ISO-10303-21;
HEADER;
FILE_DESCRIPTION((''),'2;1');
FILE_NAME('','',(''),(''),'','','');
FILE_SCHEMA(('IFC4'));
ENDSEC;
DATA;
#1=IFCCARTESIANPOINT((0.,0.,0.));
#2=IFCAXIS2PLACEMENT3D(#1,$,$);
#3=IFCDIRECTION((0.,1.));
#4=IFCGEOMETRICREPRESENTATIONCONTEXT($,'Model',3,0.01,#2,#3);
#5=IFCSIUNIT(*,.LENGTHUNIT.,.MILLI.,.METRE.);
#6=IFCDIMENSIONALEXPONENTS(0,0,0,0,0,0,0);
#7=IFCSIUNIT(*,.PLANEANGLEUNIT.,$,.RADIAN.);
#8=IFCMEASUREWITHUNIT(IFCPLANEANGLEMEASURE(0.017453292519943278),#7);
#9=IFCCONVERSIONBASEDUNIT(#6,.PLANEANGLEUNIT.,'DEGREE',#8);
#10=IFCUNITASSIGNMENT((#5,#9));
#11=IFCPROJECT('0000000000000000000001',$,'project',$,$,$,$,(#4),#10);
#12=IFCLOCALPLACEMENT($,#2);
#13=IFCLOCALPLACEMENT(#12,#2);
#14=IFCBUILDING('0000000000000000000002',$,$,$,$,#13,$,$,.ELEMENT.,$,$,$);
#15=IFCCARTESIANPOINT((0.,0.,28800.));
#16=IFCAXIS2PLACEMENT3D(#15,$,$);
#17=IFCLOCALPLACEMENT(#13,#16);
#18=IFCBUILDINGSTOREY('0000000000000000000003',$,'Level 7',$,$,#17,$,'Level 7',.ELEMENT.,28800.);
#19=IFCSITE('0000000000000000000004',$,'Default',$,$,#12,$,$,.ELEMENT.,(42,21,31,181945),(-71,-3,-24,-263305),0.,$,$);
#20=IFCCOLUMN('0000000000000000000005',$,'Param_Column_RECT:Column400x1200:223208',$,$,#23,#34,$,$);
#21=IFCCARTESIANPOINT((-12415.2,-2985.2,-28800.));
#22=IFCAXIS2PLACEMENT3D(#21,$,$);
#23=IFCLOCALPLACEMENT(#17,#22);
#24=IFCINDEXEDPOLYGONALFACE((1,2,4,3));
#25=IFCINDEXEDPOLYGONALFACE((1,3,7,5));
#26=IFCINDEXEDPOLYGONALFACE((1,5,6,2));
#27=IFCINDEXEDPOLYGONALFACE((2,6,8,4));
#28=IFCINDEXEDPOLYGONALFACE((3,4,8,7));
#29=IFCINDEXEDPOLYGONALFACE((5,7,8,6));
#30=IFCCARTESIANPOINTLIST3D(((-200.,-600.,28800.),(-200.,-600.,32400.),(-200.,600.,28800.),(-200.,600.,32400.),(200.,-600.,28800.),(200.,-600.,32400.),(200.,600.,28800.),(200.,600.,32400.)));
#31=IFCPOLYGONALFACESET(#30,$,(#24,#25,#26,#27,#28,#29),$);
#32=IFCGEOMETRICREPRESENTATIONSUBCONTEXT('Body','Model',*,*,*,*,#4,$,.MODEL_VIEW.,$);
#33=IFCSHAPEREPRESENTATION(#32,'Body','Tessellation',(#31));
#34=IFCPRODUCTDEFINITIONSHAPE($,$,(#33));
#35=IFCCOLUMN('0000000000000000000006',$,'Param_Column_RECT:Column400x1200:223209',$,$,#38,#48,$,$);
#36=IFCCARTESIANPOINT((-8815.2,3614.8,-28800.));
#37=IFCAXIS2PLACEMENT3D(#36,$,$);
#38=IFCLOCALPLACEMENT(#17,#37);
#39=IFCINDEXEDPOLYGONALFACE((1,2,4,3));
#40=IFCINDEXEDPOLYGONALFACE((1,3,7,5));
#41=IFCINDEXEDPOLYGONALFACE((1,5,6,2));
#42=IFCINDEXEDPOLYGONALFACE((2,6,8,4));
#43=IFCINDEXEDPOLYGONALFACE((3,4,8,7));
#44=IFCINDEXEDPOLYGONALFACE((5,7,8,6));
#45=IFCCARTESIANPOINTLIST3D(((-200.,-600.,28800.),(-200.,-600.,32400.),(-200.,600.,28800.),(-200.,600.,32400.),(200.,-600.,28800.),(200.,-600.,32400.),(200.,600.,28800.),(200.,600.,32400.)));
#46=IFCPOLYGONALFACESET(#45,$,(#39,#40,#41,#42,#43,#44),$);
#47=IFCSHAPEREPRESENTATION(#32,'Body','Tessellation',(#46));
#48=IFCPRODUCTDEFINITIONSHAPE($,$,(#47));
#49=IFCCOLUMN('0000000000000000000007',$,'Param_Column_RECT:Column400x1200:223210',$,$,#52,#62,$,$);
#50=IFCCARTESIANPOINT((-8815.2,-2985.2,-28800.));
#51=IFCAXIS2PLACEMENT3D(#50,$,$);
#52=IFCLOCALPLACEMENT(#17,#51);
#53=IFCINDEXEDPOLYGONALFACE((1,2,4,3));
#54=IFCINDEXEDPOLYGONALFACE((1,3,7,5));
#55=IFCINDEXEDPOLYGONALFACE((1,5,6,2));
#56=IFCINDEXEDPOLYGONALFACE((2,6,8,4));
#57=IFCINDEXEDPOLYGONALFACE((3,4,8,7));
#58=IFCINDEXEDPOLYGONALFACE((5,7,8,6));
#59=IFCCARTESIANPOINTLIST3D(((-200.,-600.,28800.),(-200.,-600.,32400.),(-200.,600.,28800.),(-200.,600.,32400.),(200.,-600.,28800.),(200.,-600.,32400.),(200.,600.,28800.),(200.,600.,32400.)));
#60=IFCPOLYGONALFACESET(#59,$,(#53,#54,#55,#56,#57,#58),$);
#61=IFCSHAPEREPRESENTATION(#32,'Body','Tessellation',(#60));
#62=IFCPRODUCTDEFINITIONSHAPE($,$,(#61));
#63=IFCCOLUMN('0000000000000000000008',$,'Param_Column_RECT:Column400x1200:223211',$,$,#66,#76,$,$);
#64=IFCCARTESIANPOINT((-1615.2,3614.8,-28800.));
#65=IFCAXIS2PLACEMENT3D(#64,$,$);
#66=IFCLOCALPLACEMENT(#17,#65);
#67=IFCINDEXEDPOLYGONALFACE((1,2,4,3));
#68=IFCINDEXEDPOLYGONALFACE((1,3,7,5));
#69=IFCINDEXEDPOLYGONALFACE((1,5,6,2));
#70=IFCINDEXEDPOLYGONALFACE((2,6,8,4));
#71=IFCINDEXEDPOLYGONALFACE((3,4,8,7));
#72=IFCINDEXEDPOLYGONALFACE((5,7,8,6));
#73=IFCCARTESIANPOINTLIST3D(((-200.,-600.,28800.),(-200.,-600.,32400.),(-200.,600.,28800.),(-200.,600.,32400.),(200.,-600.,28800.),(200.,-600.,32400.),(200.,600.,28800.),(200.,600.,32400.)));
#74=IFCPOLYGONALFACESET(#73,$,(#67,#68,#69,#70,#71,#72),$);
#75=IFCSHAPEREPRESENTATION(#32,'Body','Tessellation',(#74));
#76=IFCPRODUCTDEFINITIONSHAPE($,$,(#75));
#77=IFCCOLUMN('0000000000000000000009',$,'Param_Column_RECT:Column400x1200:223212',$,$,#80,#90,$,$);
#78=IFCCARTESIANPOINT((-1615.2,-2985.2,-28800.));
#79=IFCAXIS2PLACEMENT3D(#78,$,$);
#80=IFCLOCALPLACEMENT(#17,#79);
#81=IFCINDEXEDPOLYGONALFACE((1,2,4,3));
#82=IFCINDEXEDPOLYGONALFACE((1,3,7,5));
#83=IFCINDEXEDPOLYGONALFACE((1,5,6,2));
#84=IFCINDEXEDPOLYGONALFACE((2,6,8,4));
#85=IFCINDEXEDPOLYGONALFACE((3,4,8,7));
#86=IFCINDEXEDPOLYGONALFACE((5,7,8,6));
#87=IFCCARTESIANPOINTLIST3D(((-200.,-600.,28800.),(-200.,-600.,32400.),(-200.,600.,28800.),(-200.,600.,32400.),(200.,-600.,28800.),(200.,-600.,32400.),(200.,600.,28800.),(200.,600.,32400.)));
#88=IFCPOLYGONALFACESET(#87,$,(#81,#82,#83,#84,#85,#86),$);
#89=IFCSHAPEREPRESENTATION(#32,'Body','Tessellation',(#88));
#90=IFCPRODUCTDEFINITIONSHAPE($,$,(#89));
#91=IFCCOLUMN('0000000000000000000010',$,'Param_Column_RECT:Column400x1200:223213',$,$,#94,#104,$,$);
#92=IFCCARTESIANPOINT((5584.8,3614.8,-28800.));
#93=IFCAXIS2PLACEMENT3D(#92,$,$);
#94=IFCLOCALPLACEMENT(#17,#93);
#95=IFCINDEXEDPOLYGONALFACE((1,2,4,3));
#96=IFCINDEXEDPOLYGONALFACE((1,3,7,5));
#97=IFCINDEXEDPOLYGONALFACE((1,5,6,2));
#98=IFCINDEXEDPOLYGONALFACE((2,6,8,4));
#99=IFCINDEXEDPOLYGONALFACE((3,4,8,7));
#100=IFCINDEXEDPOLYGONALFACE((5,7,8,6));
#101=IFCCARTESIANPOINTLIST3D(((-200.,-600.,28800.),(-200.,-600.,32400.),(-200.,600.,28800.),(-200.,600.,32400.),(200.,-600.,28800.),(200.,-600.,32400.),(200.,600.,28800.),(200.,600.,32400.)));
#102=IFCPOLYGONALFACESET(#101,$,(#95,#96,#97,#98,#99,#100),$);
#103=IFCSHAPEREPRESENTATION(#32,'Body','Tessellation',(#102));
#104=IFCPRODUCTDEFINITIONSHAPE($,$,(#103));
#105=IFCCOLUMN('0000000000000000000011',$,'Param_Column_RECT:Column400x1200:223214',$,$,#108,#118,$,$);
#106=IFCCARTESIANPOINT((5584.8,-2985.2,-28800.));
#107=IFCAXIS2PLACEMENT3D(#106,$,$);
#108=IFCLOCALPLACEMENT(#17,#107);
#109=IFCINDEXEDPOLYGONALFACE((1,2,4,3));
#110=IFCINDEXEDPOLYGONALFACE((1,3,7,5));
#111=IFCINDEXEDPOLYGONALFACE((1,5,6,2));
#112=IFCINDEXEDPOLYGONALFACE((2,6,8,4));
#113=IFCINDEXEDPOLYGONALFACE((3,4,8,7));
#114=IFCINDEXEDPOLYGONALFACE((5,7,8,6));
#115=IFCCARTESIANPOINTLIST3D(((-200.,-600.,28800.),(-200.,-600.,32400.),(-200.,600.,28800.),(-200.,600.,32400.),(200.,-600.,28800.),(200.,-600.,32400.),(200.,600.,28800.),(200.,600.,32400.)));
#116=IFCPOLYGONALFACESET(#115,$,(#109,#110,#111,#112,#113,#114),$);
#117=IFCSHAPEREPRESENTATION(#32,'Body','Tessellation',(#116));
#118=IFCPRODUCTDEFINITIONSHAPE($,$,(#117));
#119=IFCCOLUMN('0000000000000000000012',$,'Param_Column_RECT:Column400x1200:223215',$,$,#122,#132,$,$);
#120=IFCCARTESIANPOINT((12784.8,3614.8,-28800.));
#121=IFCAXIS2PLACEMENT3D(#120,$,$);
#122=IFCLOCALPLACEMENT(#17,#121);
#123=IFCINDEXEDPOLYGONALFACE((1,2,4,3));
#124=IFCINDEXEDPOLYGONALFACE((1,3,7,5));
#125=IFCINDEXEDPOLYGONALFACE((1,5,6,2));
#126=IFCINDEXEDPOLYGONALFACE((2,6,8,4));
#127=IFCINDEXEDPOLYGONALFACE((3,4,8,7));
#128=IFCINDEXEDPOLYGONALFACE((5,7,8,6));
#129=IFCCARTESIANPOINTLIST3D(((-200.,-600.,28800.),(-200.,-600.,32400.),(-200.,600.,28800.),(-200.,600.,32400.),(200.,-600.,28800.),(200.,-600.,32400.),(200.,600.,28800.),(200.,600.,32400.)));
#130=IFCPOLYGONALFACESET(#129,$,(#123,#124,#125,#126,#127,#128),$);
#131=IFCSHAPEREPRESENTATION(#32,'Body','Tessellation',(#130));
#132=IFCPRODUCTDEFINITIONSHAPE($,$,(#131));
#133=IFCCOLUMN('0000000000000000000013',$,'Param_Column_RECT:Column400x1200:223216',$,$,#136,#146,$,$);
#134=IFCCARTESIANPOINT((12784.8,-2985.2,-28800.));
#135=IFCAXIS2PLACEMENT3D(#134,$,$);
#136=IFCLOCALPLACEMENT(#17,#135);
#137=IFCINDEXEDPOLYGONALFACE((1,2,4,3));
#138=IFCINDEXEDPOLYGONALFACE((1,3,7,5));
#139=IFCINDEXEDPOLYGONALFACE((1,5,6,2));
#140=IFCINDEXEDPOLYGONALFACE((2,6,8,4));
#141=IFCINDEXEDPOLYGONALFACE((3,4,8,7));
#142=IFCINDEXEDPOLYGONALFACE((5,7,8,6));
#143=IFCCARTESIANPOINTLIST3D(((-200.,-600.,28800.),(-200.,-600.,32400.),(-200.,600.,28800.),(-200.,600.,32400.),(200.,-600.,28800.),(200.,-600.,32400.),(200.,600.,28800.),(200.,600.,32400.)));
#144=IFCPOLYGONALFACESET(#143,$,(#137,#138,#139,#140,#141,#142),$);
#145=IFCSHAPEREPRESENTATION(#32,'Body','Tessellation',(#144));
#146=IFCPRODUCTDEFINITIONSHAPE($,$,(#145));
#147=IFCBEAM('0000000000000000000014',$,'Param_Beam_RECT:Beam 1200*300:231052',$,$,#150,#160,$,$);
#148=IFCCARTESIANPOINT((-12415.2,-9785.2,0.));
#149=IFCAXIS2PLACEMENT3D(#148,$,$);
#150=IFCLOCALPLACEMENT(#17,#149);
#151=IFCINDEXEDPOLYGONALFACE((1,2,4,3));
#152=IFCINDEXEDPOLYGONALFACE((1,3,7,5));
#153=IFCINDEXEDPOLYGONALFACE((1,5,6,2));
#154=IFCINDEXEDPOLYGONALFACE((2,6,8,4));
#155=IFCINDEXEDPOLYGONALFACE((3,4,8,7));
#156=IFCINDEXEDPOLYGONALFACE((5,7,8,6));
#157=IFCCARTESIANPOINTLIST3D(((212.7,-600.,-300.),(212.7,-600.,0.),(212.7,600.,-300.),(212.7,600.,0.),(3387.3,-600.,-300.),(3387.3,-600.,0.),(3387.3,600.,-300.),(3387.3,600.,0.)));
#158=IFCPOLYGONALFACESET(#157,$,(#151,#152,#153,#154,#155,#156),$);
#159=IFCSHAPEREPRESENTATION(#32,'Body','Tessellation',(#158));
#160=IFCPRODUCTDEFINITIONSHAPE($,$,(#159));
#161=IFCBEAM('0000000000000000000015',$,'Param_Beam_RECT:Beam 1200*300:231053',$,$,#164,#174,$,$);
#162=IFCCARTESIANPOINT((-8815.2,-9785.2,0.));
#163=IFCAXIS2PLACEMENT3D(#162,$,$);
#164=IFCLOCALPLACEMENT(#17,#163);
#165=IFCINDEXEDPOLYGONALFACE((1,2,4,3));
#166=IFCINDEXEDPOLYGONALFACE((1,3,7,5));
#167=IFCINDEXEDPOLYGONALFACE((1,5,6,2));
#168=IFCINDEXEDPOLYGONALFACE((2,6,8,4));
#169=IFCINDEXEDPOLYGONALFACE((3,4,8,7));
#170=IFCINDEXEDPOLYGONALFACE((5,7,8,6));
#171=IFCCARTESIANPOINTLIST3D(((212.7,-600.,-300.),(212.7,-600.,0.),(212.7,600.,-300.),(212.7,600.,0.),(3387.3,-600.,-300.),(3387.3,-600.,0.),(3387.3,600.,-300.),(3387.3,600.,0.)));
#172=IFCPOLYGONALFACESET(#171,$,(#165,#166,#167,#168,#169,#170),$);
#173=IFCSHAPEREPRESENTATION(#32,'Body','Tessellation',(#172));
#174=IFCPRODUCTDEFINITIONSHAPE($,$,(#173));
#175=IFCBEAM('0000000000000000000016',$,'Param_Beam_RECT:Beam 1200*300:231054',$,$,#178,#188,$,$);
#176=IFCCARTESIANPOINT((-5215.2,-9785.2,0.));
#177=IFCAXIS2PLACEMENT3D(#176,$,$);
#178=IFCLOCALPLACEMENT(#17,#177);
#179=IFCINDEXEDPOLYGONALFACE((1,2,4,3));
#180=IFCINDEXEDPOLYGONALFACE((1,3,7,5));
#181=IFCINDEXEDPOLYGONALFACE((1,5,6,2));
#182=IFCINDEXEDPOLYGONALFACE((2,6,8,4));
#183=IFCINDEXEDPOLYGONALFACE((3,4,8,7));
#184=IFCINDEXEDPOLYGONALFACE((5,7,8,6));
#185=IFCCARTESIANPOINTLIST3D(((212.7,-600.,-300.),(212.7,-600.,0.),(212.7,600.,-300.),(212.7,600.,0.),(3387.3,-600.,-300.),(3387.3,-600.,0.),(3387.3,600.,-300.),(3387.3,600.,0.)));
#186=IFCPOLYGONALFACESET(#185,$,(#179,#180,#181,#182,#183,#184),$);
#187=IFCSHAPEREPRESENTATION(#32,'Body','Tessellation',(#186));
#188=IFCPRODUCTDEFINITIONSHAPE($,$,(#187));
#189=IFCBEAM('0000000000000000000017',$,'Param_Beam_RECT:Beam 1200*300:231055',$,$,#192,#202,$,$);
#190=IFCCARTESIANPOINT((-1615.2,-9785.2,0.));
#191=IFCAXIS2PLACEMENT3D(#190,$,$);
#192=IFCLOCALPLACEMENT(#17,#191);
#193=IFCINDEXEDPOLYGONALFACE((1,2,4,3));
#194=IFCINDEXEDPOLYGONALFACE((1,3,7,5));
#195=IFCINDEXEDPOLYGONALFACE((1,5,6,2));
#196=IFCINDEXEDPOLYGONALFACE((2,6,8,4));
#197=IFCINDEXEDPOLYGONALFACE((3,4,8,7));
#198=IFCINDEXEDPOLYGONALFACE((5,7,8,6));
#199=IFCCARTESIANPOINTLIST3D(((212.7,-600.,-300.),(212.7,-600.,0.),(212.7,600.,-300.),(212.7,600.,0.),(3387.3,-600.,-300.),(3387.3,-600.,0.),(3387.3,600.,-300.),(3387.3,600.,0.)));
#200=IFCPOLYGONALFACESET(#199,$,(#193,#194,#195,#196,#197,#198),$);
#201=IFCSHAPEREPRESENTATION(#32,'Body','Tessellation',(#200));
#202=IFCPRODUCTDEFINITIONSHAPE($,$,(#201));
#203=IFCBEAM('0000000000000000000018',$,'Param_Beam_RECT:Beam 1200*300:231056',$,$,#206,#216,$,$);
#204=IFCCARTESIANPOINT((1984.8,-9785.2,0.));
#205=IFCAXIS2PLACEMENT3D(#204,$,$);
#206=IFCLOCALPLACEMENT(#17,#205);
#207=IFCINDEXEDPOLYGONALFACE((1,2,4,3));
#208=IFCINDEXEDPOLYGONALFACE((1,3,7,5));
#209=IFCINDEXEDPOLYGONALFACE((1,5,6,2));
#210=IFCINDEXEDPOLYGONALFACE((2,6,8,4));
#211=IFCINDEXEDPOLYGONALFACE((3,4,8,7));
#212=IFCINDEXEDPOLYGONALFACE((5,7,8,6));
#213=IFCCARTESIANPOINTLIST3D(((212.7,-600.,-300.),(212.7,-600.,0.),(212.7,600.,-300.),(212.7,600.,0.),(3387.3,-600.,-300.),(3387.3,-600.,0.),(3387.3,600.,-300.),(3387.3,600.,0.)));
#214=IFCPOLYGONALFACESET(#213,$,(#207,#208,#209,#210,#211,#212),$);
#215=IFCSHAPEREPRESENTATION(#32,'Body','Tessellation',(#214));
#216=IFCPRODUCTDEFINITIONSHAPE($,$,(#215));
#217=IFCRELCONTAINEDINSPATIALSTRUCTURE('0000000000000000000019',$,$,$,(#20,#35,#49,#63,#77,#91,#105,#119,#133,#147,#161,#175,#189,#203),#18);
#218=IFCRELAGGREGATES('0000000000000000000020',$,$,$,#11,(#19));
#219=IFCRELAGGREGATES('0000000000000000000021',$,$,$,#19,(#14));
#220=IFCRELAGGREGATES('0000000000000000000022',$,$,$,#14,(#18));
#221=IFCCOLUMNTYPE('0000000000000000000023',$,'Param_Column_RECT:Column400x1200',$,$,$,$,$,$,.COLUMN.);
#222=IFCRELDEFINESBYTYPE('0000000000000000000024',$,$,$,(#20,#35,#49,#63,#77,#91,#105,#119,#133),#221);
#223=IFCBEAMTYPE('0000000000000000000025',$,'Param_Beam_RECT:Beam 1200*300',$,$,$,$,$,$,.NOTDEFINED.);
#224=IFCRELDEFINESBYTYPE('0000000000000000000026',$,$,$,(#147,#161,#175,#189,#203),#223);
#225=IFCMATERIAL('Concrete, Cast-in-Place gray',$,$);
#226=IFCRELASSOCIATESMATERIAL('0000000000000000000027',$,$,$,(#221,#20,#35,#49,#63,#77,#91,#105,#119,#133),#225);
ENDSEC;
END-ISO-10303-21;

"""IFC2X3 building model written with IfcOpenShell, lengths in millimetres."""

from ifc_helpers import new_model, entity, si_unit, converted_unit, direction, frame, frame_2d, origin, origin_2d_with_axis, place, context, subcontext, project, spatial, rectangle, extrude, source, transform, mapped, material, type_object, type_shapes, element, save


model = new_model("IFC2X3")

# Units and contexts
model_context = context("Model", 3, precision=0.01, world=origin(), true_north=direction((0.0, 1.0)))
body_context = subcontext(model_context, "Body", "Model", "MODEL_VIEW")
ifc_project = project(units=[si_unit("LENGTHUNIT", "METRE", prefix="MILLI"), converted_unit("PLANEANGLEUNIT", "DEGREE", entity("IfcPlaneAngleMeasure", 0.017453292519943278), si_unit("PLANEANGLEUNIT", "RADIAN"), dimensions=[0, 0, 0, 0, 0, 0, 0])], contexts=[model_context])

# Site, building, storey
site_placement = place(None, origin())
site = spatial("IfcSite", under=ifc_project, at=site_placement, Name="Default", CompositionType="ELEMENT", RefLatitude=(42, 21, 31, 181945), RefLongitude=(-71, -3, -24, -263305), RefElevation=0.0)
building_placement = place(site_placement, origin())
building = spatial("IfcBuilding", under=site, at=building_placement, CompositionType="ELEMENT")
storey_placement = place(building_placement, frame((0.0, 0.0, 28800.0)))
storey = spatial("IfcBuildingStorey", under=building, at=storey_placement, Name="Level 7", LongName="Level 7", CompositionType="ELEMENT", Elevation=28800.0)

# Columns
ifc_material_1 = material(Name="Concrete, Cast-in-Place gray")
column_type_1 = type_object("IfcColumnType", Name="Param_Column_RECT:Column400x1200", PredefinedType="COLUMN", material=ifc_material_1)
shared_shape_1 = source(origin(), body_context, "Body", "SweptSolid", [
    extrude(rectangle(XDim=400.0, YDim=1200.0, at=origin_2d_with_axis()), frame((0.0, 0.0, 28800.0), z_axis=(0.0, 0.0, 1.0), x_axis=(-1.0, 0.0, 0.0)), (0.0, 0.0, 1.0), 3600.0),
])
type_shapes(column_type_1, [shared_shape_1])
for number, where, name in (
    (1, (-12415.2, -2985.2, -28800.0), "Param_Column_RECT:Column400x1200:223208"),
    (2, (-8815.2, 3614.8, -28800.0), "Param_Column_RECT:Column400x1200:223209"),
    (3, (-8815.2, -2985.2, -28800.0), "Param_Column_RECT:Column400x1200:223210"),
    (4, (-1615.2, 3614.8, -28800.0), "Param_Column_RECT:Column400x1200:223211"),
    (5, (-1615.2, -2985.2, -28800.0), "Param_Column_RECT:Column400x1200:223212"),
    (6, (5584.8, 3614.8, -28800.0), "Param_Column_RECT:Column400x1200:223213"),
    (7, (5584.8, -2985.2, -28800.0), "Param_Column_RECT:Column400x1200:223214"),
    (8, (12784.8, 3614.8, -28800.0), "Param_Column_RECT:Column400x1200:223215"),
    (9, (12784.8, -2985.2, -28800.0), "Param_Column_RECT:Column400x1200:223216"),
):
    element("IfcColumn", number, at=place(storey_placement, frame(where)), inside=storey, type_object=column_type_1, material=ifc_material_1, Name=name, context=body_context, shape_type="MappedRepresentation", body=[
        mapped(shared_shape_1, transform((0.0, 0.0, 0.0), scale=1.0)),
    ])

# Beams
beam_type = type_object("IfcBeamType", Name="Param_Beam_RECT:Beam 1200*300", PredefinedType="NOTDEFINED")
beam_1_placement = place(storey_placement, frame((-12415.2, -9785.2, 0.0)))
element("IfcBeam", 10, at=beam_1_placement, inside=storey, type_object=beam_type, Name="Param_Beam_RECT:Beam 1200*300:231052", context=body_context, shape_type="SweptSolid", body=[
    extrude(rectangle(XDim=300.0, YDim=1200.0, at=frame_2d((0.0, 0.0), x_axis=(1.0, 0.0))), frame((212.7, 0.0, -150.0), z_axis=(1.0, 0.0, 0.0), x_axis=(0.0, 0.0, -1.0)), (0.0, 0.0, 1.0), 3174.6),
])
beam_2_placement = place(storey_placement, frame((-8815.2, -9785.2, 0.0)))
element("IfcBeam", 11, at=beam_2_placement, inside=storey, type_object=beam_type, Name="Param_Beam_RECT:Beam 1200*300:231053", context=body_context, shape_type="SweptSolid", body=[
    extrude(rectangle(XDim=300.0, YDim=1200.0, at=frame_2d((0.0, 0.0), x_axis=(1.0, 0.0))), frame((212.7, 0.0, -150.0), z_axis=(1.0, 0.0, 0.0), x_axis=(0.0, 0.0, -1.0)), (0.0, 0.0, 1.0), 3174.6),
])
beam_3_placement = place(storey_placement, frame((-5215.2, -9785.2, 0.0)))
element("IfcBeam", 12, at=beam_3_placement, inside=storey, type_object=beam_type, Name="Param_Beam_RECT:Beam 1200*300:231054", context=body_context, shape_type="SweptSolid", body=[
    extrude(rectangle(XDim=300.0, YDim=1200.0, at=frame_2d((0.0, 0.0), x_axis=(1.0, 0.0))), frame((212.7, 0.0, -150.0), z_axis=(1.0, 0.0, 0.0), x_axis=(0.0, 0.0, -1.0)), (0.0, 0.0, 1.0), 3174.6),
])
beam_4_placement = place(storey_placement, frame((-1615.2, -9785.2, 0.0)))
element("IfcBeam", 13, at=beam_4_placement, inside=storey, type_object=beam_type, Name="Param_Beam_RECT:Beam 1200*300:231055", context=body_context, shape_type="SweptSolid", body=[
    extrude(rectangle(XDim=300.0, YDim=1200.0, at=origin_2d_with_axis()), frame((212.7, 0.0, -150.0), z_axis=(1.0, 0.0, 0.0), x_axis=(0.0, 0.0, -1.0)), (0.0, 0.0, 1.0), 3174.6),
])
beam_5_placement = place(storey_placement, frame((1984.8, -9785.2, 0.0)))
element("IfcBeam", 14, at=beam_5_placement, inside=storey, type_object=beam_type, Name="Param_Beam_RECT:Beam 1200*300:231056", context=body_context, shape_type="SweptSolid", body=[
    extrude(rectangle(XDim=300.0, YDim=1200.0, at=origin_2d_with_axis()), frame((212.7, 0.0, -150.0), z_axis=(1.0, 0.0, 0.0), x_axis=(0.0, 0.0, -1.0)), (0.0, 0.0, 1.0), 3174.6),
])

save(model, "model.ifc")
